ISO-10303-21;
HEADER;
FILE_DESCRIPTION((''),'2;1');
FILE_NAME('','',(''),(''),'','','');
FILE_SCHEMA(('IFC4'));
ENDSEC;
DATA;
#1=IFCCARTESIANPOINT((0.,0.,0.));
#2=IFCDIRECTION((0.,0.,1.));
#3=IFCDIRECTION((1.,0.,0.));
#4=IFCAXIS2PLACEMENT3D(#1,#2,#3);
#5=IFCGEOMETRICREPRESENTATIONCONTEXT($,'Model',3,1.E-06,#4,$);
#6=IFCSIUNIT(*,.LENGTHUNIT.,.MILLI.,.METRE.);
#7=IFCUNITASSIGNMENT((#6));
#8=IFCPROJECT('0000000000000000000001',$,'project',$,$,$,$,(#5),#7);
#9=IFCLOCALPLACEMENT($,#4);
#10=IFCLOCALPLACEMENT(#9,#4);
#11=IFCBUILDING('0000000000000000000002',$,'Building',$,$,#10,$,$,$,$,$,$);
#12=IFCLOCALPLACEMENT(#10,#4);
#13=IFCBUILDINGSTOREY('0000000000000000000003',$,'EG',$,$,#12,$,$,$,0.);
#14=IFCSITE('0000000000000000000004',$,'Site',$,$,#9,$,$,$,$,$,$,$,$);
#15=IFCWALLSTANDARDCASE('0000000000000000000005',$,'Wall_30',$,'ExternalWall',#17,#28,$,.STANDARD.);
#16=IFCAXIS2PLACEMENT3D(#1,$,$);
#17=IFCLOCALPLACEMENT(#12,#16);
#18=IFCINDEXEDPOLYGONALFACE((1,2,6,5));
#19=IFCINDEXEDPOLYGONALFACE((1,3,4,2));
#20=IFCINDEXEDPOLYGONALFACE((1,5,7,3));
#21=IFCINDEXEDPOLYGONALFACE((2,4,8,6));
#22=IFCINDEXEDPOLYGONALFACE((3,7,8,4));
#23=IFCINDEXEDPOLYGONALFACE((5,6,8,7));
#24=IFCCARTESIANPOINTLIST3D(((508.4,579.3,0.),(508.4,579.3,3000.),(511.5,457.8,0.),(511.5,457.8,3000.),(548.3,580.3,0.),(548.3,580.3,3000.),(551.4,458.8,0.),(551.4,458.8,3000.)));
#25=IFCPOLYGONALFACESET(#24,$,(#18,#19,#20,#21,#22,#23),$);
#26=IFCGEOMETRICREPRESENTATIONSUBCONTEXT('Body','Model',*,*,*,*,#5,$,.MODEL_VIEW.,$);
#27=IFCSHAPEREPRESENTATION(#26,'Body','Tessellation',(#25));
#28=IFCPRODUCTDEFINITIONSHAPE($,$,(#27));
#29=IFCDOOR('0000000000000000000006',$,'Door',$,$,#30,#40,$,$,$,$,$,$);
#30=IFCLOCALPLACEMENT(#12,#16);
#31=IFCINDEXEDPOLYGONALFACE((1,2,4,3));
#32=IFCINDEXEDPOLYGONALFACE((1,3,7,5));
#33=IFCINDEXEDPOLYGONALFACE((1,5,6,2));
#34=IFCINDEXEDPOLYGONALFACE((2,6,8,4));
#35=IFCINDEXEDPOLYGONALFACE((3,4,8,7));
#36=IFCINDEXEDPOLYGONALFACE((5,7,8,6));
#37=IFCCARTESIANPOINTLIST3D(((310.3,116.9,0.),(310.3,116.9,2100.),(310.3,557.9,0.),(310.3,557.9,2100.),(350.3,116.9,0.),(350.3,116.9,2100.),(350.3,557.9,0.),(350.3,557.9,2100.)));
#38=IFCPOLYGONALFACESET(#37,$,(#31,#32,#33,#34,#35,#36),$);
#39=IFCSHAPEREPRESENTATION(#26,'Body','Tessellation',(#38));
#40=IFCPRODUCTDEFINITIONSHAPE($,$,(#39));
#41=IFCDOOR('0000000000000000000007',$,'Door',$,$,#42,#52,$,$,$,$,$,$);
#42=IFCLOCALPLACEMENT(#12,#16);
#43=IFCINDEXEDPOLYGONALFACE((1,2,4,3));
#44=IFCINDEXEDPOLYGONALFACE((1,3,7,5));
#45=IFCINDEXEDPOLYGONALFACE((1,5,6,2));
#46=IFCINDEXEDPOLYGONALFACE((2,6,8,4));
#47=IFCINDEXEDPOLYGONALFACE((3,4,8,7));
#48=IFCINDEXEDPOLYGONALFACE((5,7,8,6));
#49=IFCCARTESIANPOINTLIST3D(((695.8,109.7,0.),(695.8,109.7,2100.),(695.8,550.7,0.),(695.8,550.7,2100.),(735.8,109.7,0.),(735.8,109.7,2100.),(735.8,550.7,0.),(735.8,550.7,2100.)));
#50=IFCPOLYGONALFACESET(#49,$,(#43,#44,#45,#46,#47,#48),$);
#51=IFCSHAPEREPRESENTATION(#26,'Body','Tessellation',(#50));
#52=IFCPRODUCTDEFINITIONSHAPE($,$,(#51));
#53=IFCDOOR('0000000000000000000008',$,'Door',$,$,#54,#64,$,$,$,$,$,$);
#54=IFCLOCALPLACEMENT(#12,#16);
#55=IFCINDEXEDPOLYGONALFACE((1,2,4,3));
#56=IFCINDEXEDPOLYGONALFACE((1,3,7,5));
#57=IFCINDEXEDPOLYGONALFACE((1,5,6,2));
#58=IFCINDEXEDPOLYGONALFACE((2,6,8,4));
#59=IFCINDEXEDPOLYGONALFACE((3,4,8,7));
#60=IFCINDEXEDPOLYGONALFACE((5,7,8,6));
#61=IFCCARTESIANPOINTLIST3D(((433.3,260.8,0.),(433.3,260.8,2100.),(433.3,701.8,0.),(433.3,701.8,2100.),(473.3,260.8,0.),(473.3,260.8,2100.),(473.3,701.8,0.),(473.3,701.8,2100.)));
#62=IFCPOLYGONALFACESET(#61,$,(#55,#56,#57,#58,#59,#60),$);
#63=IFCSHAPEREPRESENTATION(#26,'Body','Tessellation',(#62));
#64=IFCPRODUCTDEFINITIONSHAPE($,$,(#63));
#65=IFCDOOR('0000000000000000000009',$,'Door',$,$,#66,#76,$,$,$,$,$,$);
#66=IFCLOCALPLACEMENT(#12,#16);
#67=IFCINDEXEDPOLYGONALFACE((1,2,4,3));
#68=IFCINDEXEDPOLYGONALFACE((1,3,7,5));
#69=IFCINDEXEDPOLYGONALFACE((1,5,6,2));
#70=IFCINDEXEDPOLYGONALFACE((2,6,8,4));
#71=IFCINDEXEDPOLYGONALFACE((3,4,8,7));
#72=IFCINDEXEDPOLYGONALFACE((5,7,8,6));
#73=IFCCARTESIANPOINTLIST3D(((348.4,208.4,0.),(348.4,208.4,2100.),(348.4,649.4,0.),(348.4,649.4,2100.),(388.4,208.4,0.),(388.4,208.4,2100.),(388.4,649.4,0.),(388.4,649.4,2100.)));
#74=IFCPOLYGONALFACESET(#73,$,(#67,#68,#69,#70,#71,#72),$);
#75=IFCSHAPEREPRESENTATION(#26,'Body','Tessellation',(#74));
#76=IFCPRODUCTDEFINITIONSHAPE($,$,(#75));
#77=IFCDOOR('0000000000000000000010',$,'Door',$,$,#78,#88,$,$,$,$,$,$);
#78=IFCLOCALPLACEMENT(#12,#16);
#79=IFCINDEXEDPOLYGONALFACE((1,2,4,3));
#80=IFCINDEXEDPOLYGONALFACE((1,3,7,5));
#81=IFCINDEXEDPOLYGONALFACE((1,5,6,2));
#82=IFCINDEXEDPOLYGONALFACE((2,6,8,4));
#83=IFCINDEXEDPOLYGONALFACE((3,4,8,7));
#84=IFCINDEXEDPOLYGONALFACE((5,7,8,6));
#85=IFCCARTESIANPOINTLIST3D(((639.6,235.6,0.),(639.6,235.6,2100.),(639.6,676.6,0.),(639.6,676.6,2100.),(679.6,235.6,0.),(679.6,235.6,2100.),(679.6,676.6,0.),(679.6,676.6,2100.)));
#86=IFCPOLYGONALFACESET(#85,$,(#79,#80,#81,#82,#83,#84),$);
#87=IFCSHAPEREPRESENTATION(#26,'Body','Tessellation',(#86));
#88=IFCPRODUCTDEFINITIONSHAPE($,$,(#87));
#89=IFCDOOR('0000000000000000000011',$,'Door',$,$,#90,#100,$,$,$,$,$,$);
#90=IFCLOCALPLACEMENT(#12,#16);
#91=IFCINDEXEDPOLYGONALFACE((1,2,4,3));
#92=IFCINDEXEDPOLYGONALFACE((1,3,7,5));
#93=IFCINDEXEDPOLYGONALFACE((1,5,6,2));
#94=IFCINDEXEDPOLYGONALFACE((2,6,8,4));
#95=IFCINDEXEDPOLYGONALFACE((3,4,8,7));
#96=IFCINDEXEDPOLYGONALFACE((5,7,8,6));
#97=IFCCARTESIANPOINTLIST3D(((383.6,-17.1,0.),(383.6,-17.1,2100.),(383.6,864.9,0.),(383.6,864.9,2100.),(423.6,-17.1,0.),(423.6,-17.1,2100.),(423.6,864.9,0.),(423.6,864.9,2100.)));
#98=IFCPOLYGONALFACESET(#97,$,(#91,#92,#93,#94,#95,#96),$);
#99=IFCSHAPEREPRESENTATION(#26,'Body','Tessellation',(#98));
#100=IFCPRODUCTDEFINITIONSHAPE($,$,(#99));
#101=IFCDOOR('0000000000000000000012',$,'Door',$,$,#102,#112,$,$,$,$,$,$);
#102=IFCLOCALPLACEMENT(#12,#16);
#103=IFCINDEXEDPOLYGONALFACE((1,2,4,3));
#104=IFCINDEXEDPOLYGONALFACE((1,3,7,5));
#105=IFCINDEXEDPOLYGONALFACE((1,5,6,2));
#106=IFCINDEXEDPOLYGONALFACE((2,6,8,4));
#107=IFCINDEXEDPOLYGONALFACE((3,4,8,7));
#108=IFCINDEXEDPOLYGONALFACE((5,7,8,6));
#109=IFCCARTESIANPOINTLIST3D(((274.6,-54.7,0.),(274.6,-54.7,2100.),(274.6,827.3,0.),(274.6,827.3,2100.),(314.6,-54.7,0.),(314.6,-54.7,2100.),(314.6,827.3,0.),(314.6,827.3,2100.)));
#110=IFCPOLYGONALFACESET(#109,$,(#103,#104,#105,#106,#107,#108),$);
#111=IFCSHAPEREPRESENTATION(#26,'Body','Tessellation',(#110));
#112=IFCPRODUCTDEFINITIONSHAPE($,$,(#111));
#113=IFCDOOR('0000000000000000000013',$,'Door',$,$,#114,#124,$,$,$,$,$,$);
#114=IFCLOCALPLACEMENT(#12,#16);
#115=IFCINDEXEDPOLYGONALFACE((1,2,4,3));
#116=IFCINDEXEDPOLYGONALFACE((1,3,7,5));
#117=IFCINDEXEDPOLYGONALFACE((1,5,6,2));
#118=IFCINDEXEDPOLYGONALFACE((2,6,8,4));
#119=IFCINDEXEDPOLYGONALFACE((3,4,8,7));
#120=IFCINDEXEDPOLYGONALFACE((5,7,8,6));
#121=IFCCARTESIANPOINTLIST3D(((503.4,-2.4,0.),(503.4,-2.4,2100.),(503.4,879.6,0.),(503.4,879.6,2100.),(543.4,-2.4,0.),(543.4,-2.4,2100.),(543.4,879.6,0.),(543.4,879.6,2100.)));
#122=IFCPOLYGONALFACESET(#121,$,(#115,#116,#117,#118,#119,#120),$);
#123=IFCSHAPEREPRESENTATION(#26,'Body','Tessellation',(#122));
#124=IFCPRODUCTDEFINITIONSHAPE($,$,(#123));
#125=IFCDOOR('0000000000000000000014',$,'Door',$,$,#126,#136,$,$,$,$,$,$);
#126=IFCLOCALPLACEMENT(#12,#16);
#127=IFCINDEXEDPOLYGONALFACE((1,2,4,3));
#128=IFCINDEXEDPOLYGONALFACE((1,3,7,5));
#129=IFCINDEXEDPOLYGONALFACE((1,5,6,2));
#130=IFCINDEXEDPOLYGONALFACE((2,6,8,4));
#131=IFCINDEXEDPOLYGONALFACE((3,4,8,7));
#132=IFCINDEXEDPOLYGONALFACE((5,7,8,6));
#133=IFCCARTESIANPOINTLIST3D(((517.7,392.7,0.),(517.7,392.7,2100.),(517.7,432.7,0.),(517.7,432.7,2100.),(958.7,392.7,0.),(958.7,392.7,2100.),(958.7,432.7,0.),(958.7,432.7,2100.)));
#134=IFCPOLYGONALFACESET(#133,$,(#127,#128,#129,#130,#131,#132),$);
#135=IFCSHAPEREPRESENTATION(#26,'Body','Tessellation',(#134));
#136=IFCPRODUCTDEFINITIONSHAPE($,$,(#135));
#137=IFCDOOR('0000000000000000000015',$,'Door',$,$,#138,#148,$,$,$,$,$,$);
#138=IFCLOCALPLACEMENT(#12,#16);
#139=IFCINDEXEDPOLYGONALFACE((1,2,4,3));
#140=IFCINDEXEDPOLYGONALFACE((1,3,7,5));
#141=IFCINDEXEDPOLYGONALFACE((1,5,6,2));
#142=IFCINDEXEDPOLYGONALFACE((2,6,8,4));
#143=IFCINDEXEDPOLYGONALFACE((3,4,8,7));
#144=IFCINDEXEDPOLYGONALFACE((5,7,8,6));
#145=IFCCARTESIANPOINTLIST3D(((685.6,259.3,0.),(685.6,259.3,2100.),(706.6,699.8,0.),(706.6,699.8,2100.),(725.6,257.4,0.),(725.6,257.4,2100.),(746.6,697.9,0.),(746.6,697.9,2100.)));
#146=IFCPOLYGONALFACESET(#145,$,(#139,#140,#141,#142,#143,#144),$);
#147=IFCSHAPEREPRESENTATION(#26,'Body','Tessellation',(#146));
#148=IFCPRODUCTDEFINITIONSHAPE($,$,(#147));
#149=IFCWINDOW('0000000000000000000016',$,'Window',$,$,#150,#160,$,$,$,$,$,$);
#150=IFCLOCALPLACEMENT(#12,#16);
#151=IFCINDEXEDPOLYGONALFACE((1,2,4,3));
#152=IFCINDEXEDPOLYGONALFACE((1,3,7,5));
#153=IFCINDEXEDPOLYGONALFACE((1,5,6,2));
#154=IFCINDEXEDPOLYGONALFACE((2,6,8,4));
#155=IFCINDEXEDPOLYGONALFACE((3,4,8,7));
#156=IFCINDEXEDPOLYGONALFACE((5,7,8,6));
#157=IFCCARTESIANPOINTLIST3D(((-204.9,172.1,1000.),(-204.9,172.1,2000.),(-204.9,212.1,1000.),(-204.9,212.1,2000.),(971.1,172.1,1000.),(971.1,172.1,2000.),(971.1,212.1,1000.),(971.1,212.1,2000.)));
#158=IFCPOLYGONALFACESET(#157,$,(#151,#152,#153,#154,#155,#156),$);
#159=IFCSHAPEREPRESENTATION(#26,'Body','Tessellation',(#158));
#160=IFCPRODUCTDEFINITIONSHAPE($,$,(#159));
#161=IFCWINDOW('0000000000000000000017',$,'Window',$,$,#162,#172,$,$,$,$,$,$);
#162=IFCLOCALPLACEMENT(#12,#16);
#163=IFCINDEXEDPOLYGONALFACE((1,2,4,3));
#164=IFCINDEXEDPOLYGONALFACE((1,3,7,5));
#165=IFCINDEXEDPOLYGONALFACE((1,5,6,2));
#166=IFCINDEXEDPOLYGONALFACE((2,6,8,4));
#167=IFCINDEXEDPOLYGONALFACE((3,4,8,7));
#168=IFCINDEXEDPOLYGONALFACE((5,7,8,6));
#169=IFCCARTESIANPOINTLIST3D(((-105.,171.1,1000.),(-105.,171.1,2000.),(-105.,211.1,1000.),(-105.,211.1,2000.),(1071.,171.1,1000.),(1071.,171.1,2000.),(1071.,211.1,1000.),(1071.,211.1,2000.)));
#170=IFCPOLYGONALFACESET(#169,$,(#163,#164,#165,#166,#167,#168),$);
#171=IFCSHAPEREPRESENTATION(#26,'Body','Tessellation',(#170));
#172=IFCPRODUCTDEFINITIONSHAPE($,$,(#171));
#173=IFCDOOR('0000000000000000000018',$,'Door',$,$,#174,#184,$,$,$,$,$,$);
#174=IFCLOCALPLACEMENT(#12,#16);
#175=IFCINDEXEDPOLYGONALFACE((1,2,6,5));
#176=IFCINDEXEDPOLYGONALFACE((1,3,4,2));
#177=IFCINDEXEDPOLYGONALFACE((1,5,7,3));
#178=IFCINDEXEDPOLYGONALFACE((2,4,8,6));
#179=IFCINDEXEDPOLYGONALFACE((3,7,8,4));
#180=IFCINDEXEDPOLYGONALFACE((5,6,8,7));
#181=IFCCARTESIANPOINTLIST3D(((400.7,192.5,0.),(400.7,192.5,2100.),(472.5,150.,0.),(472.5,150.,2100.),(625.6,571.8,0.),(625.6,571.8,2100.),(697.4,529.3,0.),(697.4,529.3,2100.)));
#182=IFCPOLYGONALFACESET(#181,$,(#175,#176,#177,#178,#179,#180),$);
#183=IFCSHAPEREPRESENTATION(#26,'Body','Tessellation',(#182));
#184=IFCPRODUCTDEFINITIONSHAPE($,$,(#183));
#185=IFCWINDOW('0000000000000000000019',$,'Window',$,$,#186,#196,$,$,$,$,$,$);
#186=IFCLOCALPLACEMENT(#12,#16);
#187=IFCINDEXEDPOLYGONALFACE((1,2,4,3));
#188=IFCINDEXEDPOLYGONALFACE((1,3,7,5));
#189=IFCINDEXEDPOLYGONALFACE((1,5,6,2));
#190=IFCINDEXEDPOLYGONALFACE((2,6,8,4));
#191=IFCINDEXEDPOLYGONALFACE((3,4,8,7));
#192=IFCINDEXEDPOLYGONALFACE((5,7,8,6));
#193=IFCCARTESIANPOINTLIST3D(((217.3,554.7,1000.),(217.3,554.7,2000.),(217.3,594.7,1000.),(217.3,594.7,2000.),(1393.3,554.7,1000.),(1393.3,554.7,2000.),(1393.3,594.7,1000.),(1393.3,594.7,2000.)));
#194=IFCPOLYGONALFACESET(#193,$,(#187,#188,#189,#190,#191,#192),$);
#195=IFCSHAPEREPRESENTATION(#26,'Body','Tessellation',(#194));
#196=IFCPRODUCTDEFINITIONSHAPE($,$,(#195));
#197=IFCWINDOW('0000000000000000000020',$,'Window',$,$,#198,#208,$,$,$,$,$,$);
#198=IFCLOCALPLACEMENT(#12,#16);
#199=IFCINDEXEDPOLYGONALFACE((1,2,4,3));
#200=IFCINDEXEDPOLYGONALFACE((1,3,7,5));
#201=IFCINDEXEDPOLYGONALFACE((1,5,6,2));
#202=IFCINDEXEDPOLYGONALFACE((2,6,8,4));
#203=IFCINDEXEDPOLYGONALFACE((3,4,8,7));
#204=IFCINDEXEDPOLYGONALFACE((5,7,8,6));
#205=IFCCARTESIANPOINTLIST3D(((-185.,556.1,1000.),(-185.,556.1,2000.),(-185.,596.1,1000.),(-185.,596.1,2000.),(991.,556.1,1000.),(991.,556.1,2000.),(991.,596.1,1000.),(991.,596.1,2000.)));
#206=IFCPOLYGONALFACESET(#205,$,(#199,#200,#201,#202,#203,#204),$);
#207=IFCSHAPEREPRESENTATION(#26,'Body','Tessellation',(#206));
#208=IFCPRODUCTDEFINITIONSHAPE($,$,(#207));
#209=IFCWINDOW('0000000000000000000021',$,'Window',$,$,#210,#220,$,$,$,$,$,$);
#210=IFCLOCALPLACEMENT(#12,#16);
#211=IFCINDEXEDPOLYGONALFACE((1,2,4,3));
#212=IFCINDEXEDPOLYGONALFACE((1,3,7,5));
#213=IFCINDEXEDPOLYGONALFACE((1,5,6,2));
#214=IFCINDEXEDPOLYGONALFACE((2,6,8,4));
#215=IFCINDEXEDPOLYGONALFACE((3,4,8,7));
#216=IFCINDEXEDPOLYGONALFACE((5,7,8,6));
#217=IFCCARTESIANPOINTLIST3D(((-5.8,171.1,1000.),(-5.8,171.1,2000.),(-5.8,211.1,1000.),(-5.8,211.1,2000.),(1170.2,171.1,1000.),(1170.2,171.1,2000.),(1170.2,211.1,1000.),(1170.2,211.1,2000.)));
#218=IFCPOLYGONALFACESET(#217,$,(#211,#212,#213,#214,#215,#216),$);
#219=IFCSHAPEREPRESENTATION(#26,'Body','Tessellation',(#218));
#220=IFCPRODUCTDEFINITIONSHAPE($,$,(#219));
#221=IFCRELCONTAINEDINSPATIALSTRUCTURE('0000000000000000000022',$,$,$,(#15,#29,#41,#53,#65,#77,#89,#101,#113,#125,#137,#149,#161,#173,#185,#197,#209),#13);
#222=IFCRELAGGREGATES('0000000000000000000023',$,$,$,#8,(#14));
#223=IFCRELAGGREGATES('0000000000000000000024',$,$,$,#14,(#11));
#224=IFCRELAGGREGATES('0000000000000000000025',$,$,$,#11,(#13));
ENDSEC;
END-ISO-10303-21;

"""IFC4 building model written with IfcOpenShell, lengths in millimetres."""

from ifc_helpers import new_model, si_unit, frame, origin_with_axes, place, context, subcontext, project, spatial, rectangle, extrude, element, save


model = new_model("IFC4")

# Units and contexts
model_context = context("Model", 3, precision=1e-06, world=origin_with_axes())
body_context = subcontext(model_context, "Body", "Model", "MODEL_VIEW")
ifc_project = project(units=[si_unit("LENGTHUNIT", "METRE", prefix="MILLI")], contexts=[model_context])

# Site, building, storey
site_placement = place(None, origin_with_axes())
site = spatial("IfcSite", under=ifc_project, at=site_placement, Name="Site")
building_placement = place(site_placement, origin_with_axes())
building = spatial("IfcBuilding", under=site, at=building_placement, Name="Building")
storey_placement = place(building_placement, origin_with_axes())
storey = spatial("IfcBuildingStorey", under=building, at=storey_placement, Name="EG", Elevation=0.0)

# Wall
wall_placement = place(storey_placement, origin_with_axes())
element("IfcWallStandardCase", 1, at=wall_placement, inside=storey, Name="Wall_30", ObjectType="ExternalWall", PredefinedType="STANDARD", context=body_context, shape_type="SweptSolid", body=[
    extrude(rectangle(XDim=121.6, YDim=40.0), frame((529.9, 519.0, 0.0), z_axis=(0.0, 0.0, 1.0), x_axis=(-0.025416, 0.999677, 0.0)), (0.0, 0.0, 1.0), 3000.0),
])

# Doors
door_1_placement = place(storey_placement, origin_with_axes())
element("IfcDoor", 2, at=door_1_placement, inside=storey, Name="Door", context=body_context, shape_type="SweptSolid", body=[
    extrude(rectangle(XDim=441.0, YDim=40.0), frame((330.3, 337.4, 0.0), z_axis=(0.0, 0.0, 1.0), x_axis=(0.0, 1.0, 0.0)), (0.0, 0.0, 1.0), 2100.0),
])
door_2_placement = place(storey_placement, origin_with_axes())
element("IfcDoor", 3, at=door_2_placement, inside=storey, Name="Door", context=body_context, shape_type="SweptSolid", body=[
    extrude(rectangle(XDim=441.0, YDim=40.0), frame((715.8, 330.2, 0.0), z_axis=(0.0, 0.0, 1.0), x_axis=(0.0, -1.0, 0.0)), (0.0, 0.0, 1.0), 2100.0),
])
door_3_placement = place(storey_placement, origin_with_axes())
element("IfcDoor", 4, at=door_3_placement, inside=storey, Name="Door", context=body_context, shape_type="SweptSolid", body=[
    extrude(rectangle(XDim=441.0, YDim=40.0), frame((453.3, 481.3, 0.0), z_axis=(0.0, 0.0, 1.0), x_axis=(0.0, 1.0, 0.0)), (0.0, 0.0, 1.0), 2100.0),
])
door_4_placement = place(storey_placement, origin_with_axes())
element("IfcDoor", 5, at=door_4_placement, inside=storey, Name="Door", context=body_context, shape_type="SweptSolid", body=[
    extrude(rectangle(XDim=441.0, YDim=40.0), frame((368.4, 428.9, 0.0), z_axis=(0.0, 0.0, 1.0), x_axis=(0.0, 1.0, 0.0)), (0.0, 0.0, 1.0), 2100.0),
])
door_5_placement = place(storey_placement, origin_with_axes())
element("IfcDoor", 6, at=door_5_placement, inside=storey, Name="Door", context=body_context, shape_type="SweptSolid", body=[
    extrude(rectangle(XDim=441.0, YDim=40.0), frame((659.6, 456.1, 0.0), z_axis=(0.0, 0.0, 1.0), x_axis=(0.0, 1.0, 0.0)), (0.0, 0.0, 1.0), 2100.0),
])
door_6_placement = place(storey_placement, origin_with_axes())
element("IfcDoor", 7, at=door_6_placement, inside=storey, Name="Door", context=body_context, shape_type="SweptSolid", body=[
    extrude(rectangle(XDim=882.0, YDim=40.0), frame((403.6, 423.9, 0.0), z_axis=(0.0, 0.0, 1.0), x_axis=(0.0, 1.0, 0.0)), (0.0, 0.0, 1.0), 2100.0),
])
door_7_placement = place(storey_placement, origin_with_axes())
element("IfcDoor", 8, at=door_7_placement, inside=storey, Name="Door", context=body_context, shape_type="SweptSolid", body=[
    extrude(rectangle(XDim=882.0, YDim=40.0), frame((294.6, 386.3, 0.0), z_axis=(0.0, 0.0, 1.0), x_axis=(0.0, 1.0, 0.0)), (0.0, 0.0, 1.0), 2100.0),
])
door_8_placement = place(storey_placement, origin_with_axes())
element("IfcDoor", 9, at=door_8_placement, inside=storey, Name="Door", context=body_context, shape_type="SweptSolid", body=[
    extrude(rectangle(XDim=882.0, YDim=40.0), frame((523.4, 438.6, 0.0), z_axis=(0.0, 0.0, 1.0), x_axis=(0.0, 1.0, 0.0)), (0.0, 0.0, 1.0), 2100.0),
])
door_9_placement = place(storey_placement, origin_with_axes())
element("IfcDoor", 10, at=door_9_placement, inside=storey, Name="Door", context=body_context, shape_type="SweptSolid", body=[
    extrude(rectangle(XDim=441.0, YDim=40.0), frame((738.2, 412.7, 0.0), z_axis=(0.0, 0.0, 1.0), x_axis=(-1.0, 0.0, 0.0)), (0.0, 0.0, 1.0), 2100.0),
])
door_10_placement = place(storey_placement, origin_with_axes())
element("IfcDoor", 11, at=door_10_placement, inside=storey, Name="Door", context=body_context, shape_type="SweptSolid", body=[
    extrude(rectangle(XDim=441.0, YDim=40.0), frame((716.1, 478.6, 0.0), z_axis=(0.0, 0.0, 1.0), x_axis=(-0.047565, -0.998868, 0.0)), (0.0, 0.0, 1.0), 2100.0),
])

# Windows
window_1_placement = place(storey_placement, origin_with_axes())
element("IfcWindow", 12, at=window_1_placement, inside=storey, Name="Window", context=body_context, shape_type="SweptSolid", body=[
    extrude(rectangle(XDim=1176.0, YDim=40.0), frame((383.1, 192.1, 1000.0), z_axis=(0.0, 0.0, 1.0), x_axis=(-1.0, 0.0, 0.0)), (0.0, 0.0, 1.0), 1000.0),
])
window_2_placement = place(storey_placement, origin_with_axes())
element("IfcWindow", 13, at=window_2_placement, inside=storey, Name="Window", context=body_context, shape_type="SweptSolid", body=[
    extrude(rectangle(XDim=1176.0, YDim=40.0), frame((483.0, 191.1, 1000.0), z_axis=(0.0, 0.0, 1.0), x_axis=(-1.0, 0.0, 0.0)), (0.0, 0.0, 1.0), 1000.0),
])

# Door
door_11_placement = place(storey_placement, origin_with_axes())
element("IfcDoor", 14, at=door_11_placement, inside=storey, Name="Door", context=body_context, shape_type="SweptSolid", body=[
    extrude(rectangle(XDim=441.0, YDim=83.5), frame((549.1, 360.9, 0.0), z_axis=(0.0, 0.0, 1.0), x_axis=(-0.510011, -0.860168, 0.0)), (0.0, 0.0, 1.0), 2100.0),
])

# Windows
window_3_placement = place(storey_placement, origin_with_axes())
element("IfcWindow", 15, at=window_3_placement, inside=storey, Name="Window", context=body_context, shape_type="SweptSolid", body=[
    extrude(rectangle(XDim=1176.0, YDim=40.0), frame((805.3, 574.7, 1000.0), z_axis=(0.0, 0.0, 1.0), x_axis=(-1.0, 0.0, 0.0)), (0.0, 0.0, 1.0), 1000.0),
])
window_4_placement = place(storey_placement, origin_with_axes())
element("IfcWindow", 16, at=window_4_placement, inside=storey, Name="Window", context=body_context, shape_type="SweptSolid", body=[
    extrude(rectangle(XDim=1176.0, YDim=40.0), frame((403.0, 576.1, 1000.0), z_axis=(0.0, 0.0, 1.0), x_axis=(-1.0, 0.0, 0.0)), (0.0, 0.0, 1.0), 1000.0),
])
window_5_placement = place(storey_placement, origin_with_axes())
element("IfcWindow", 17, at=window_5_placement, inside=storey, Name="Window", context=body_context, shape_type="SweptSolid", body=[
    extrude(rectangle(XDim=1176.0, YDim=40.0), frame((582.2, 191.1, 1000.0), z_axis=(0.0, 0.0, 1.0), x_axis=(-1.0, 0.0, 0.0)), (0.0, 0.0, 1.0), 1000.0),
])

save(model, "model.ifc")
